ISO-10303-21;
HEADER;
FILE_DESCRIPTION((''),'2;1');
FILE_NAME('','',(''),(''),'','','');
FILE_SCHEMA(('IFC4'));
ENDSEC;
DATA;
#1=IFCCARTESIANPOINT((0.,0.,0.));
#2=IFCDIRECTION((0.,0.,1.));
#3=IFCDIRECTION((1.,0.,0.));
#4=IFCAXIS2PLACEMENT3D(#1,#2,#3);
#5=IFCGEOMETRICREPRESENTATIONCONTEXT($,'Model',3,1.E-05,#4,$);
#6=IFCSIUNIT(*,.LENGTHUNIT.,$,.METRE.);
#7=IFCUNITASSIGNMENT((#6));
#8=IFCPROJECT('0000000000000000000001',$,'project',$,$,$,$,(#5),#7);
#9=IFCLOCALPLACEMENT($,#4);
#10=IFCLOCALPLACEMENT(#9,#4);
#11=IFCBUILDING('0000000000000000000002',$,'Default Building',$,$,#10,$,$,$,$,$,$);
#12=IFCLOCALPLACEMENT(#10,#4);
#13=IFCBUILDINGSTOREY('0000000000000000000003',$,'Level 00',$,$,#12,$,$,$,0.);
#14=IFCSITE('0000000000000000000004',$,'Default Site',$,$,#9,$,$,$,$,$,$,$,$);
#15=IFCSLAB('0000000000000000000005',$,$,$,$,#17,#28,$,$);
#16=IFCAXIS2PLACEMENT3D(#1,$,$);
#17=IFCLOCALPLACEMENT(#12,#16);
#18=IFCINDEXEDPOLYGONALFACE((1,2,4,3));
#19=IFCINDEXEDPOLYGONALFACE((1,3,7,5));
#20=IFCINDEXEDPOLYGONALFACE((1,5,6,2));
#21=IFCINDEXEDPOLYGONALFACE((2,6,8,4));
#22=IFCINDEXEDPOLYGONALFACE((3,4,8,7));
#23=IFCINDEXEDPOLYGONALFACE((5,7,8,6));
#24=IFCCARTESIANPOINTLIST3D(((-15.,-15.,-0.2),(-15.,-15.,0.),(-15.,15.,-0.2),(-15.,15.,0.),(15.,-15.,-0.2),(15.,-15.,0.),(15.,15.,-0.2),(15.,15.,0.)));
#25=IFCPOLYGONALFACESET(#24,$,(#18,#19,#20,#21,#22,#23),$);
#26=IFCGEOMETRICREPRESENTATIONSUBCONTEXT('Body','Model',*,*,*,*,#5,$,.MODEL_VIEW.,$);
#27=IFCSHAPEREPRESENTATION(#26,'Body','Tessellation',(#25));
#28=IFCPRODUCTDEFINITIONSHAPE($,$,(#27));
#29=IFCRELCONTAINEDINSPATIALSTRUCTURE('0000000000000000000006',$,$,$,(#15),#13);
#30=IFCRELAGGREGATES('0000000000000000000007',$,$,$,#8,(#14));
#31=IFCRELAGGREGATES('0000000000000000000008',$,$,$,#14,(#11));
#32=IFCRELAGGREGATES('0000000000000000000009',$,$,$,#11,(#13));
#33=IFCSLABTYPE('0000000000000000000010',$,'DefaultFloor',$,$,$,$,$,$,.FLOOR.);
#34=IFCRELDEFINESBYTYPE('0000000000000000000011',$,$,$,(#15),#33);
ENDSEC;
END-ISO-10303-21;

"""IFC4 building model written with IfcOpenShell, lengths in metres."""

from ifc_helpers import new_model, si_unit, origin_with_axes, place, context, subcontext, project, spatial, polyline, outline, extrude, type_object, element, save


model = new_model("IFC4")

# Units and contexts
model_context = context("Model", 3, precision=1e-05, world=origin_with_axes())
body_context = subcontext(model_context, "Body", "Model", "MODEL_VIEW")
ifc_project = project(units=[si_unit("LENGTHUNIT", "METRE")], contexts=[model_context])

# Site, building, storey
site_placement = place(None, origin_with_axes())
site = spatial("IfcSite", under=ifc_project, at=site_placement, Name="Default Site")
building_placement = place(site_placement, origin_with_axes())
building = spatial("IfcBuilding", under=site, at=building_placement, Name="Default Building")
storey_placement = place(building_placement, origin_with_axes())
storey = spatial("IfcBuildingStorey", under=building, at=storey_placement, Name="Level 00", Elevation=0.0)

# Slab
slab_type = type_object("IfcSlabType", Name="DefaultFloor", PredefinedType="FLOOR")
slab_placement = place(storey_placement, origin_with_axes())
element("IfcSlab", 1, at=slab_placement, inside=storey, type_object=slab_type, context=body_context, shape_type="SweptSolid", body=[
    extrude(outline(polyline([(-15.0, -15.0), (-15.0, 15.0), (15.0, 15.0), (15.0, -15.0), (-15.0, -15.0)])), origin_with_axes(), (0.0, 0.0, -1.0), 0.2),
])

save(model, "model.ifc")
